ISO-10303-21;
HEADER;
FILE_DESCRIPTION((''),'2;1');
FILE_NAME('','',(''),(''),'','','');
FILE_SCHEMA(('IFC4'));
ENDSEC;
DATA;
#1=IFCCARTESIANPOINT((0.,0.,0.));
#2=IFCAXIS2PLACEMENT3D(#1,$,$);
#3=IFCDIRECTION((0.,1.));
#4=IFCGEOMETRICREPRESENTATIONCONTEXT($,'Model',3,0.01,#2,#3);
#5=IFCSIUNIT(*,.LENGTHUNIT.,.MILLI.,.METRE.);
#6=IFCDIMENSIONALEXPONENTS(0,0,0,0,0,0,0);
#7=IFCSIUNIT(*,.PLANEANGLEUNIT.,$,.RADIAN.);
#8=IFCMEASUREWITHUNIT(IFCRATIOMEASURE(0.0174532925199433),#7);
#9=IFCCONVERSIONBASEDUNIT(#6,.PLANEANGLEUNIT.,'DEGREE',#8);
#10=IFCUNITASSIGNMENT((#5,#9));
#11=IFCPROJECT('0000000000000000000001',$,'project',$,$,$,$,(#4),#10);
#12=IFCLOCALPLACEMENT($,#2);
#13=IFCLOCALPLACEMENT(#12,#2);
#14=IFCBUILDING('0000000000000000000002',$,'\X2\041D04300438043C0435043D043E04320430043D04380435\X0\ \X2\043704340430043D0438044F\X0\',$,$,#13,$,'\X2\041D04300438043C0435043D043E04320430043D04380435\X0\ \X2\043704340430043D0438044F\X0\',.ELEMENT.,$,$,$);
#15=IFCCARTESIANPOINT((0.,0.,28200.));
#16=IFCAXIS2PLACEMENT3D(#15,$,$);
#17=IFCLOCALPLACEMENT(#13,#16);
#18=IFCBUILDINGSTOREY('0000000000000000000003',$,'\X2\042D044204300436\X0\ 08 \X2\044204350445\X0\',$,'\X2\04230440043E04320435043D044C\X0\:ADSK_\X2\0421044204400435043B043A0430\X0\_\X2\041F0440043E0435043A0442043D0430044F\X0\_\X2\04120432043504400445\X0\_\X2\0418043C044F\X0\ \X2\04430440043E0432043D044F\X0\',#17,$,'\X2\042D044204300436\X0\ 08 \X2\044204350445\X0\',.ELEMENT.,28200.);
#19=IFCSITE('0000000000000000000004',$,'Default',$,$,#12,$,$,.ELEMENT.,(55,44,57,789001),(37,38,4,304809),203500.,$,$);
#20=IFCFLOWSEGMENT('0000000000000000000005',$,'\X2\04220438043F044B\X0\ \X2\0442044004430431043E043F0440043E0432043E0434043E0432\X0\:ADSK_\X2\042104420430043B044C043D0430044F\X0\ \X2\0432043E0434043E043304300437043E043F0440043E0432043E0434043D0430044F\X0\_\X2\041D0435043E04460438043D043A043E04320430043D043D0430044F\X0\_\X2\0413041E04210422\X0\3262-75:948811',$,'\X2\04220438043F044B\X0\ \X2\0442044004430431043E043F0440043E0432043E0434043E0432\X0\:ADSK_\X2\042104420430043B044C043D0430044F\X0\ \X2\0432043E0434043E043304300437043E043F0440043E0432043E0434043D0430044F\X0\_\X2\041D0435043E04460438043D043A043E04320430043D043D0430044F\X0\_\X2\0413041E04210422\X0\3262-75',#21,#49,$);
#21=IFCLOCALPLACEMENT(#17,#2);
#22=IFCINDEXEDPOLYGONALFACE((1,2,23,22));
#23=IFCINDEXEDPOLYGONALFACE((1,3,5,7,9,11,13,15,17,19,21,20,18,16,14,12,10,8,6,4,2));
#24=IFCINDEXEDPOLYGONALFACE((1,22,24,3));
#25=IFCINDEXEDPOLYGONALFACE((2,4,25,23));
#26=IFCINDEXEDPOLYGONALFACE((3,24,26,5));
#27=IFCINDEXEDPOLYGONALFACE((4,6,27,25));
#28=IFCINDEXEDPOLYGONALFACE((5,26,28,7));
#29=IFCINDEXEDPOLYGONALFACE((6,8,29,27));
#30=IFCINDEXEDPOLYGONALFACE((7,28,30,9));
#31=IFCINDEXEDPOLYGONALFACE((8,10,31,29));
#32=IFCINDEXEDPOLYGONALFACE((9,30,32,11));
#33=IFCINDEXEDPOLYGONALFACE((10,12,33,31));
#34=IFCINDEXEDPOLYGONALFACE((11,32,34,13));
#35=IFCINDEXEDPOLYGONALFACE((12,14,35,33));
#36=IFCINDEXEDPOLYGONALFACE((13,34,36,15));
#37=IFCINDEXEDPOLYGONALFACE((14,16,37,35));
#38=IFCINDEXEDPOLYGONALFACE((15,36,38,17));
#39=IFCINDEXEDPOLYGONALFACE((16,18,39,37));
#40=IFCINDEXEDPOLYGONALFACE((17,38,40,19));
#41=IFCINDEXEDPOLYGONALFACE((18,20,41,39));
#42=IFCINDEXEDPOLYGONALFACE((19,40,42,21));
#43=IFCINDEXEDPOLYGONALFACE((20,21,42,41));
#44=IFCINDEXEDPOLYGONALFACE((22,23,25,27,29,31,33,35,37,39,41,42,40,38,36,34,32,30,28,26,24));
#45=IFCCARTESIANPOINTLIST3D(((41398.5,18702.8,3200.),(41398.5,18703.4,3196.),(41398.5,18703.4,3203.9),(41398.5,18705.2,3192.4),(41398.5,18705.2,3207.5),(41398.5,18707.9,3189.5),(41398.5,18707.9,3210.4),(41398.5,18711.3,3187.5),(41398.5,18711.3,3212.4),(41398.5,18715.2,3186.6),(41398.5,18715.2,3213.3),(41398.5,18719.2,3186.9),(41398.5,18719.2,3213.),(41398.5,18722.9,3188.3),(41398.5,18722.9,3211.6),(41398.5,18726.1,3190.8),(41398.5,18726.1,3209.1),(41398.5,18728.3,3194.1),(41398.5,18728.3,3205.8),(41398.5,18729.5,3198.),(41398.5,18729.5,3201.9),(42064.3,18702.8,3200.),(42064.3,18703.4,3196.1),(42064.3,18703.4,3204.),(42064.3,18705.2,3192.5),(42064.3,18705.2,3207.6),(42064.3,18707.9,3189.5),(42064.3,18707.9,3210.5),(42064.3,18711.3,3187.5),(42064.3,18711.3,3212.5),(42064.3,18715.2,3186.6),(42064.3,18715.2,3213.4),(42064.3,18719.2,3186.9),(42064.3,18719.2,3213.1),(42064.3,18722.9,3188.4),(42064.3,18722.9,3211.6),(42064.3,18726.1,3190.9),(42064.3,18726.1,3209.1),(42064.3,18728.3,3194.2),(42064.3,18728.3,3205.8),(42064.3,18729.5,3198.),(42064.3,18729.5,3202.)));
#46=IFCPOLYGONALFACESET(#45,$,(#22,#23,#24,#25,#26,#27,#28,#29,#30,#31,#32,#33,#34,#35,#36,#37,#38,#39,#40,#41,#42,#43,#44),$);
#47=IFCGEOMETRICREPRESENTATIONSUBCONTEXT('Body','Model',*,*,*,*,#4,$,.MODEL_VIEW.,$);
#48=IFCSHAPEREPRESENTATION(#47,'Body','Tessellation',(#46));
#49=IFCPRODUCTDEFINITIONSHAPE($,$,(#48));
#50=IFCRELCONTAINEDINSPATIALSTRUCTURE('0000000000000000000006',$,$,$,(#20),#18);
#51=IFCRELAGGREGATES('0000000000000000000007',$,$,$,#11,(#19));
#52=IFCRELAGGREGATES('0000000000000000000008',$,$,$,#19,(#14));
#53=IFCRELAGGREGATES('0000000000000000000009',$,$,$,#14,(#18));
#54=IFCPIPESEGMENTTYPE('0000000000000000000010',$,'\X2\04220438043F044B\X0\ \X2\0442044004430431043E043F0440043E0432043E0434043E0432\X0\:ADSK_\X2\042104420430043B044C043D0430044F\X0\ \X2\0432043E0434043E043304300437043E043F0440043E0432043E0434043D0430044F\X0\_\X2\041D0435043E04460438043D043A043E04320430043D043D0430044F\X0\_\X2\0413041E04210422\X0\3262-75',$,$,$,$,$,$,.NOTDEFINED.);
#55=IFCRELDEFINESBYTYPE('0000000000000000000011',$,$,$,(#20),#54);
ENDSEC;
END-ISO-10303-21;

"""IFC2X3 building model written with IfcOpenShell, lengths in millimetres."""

from ifc_helpers import new_model, entity, si_unit, converted_unit, direction, frame, origin, origin_2d_with_axis, place, context, subcontext, project, spatial, circle, extrude, type_object, element, save


model = new_model("IFC2X3")

# Units and contexts
model_context = context("Model", 3, precision=0.01, world=origin(), true_north=direction((0.0, 1.0)))
body_context = subcontext(model_context, "Body", "Model", "MODEL_VIEW")
ifc_project = project(units=[si_unit("LENGTHUNIT", "METRE", prefix="MILLI"), converted_unit("PLANEANGLEUNIT", "DEGREE", entity("IfcRatioMeasure", 0.0174532925199433), si_unit("PLANEANGLEUNIT", "RADIAN"), dimensions=[0, 0, 0, 0, 0, 0, 0])], contexts=[model_context])

# Site, building, storey
site_placement = place(None, origin())
site = spatial("IfcSite", under=ifc_project, at=site_placement, Name="Default", CompositionType="ELEMENT", RefLatitude=(55, 44, 57, 789001), RefLongitude=(37, 38, 4, 304809), RefElevation=203500.0)
building_placement = place(site_placement, origin())
building = spatial("IfcBuilding", under=site, at=building_placement, Name="Наименование здания", LongName="Наименование здания", CompositionType="ELEMENT")
storey_placement = place(building_placement, frame((0.0, 0.0, 28200.0)))
storey = spatial("IfcBuildingStorey", under=building, at=storey_placement, Name="Этаж 08 тех", ObjectType="Уровень:ADSK_Стрелка_Проектная_Вверх_Имя уровня", LongName="Этаж 08 тех", CompositionType="ELEMENT", Elevation=28200.0)

# Flow segment
pipe_segment_type = type_object("IfcPipeSegmentType", Name="Типы трубопроводов:ADSK_Стальная водогазопроводная_Неоцинкованная_ГОСТ3262-75", PredefinedType="NOTDEFINED")
flow_segment_1_placement = place(storey_placement, frame((41398.5, 18701.2, 3184.9)))
element("IfcFlowSegment", 1, at=flow_segment_1_placement, inside=storey, type_object=pipe_segment_type, Name="Типы трубопроводов:ADSK_Стальная водогазопроводная_Неоцинкованная_ГОСТ3262-75:948811", ObjectType="Типы трубопроводов:ADSK_Стальная водогазопроводная_Неоцинкованная_ГОСТ3262-75", context=body_context, shape_type="SweptSolid", body=[
    extrude(circle(Radius=13.4, at=origin_2d_with_axis()), frame((0.0, 15.0, 15.0), z_axis=(1.0, 0.0, 0.000085), x_axis=(0.0, -1.0, 0.0)), (0.0, 0.0, 1.0), 665.8),
])

save(model, "model.ifc")
